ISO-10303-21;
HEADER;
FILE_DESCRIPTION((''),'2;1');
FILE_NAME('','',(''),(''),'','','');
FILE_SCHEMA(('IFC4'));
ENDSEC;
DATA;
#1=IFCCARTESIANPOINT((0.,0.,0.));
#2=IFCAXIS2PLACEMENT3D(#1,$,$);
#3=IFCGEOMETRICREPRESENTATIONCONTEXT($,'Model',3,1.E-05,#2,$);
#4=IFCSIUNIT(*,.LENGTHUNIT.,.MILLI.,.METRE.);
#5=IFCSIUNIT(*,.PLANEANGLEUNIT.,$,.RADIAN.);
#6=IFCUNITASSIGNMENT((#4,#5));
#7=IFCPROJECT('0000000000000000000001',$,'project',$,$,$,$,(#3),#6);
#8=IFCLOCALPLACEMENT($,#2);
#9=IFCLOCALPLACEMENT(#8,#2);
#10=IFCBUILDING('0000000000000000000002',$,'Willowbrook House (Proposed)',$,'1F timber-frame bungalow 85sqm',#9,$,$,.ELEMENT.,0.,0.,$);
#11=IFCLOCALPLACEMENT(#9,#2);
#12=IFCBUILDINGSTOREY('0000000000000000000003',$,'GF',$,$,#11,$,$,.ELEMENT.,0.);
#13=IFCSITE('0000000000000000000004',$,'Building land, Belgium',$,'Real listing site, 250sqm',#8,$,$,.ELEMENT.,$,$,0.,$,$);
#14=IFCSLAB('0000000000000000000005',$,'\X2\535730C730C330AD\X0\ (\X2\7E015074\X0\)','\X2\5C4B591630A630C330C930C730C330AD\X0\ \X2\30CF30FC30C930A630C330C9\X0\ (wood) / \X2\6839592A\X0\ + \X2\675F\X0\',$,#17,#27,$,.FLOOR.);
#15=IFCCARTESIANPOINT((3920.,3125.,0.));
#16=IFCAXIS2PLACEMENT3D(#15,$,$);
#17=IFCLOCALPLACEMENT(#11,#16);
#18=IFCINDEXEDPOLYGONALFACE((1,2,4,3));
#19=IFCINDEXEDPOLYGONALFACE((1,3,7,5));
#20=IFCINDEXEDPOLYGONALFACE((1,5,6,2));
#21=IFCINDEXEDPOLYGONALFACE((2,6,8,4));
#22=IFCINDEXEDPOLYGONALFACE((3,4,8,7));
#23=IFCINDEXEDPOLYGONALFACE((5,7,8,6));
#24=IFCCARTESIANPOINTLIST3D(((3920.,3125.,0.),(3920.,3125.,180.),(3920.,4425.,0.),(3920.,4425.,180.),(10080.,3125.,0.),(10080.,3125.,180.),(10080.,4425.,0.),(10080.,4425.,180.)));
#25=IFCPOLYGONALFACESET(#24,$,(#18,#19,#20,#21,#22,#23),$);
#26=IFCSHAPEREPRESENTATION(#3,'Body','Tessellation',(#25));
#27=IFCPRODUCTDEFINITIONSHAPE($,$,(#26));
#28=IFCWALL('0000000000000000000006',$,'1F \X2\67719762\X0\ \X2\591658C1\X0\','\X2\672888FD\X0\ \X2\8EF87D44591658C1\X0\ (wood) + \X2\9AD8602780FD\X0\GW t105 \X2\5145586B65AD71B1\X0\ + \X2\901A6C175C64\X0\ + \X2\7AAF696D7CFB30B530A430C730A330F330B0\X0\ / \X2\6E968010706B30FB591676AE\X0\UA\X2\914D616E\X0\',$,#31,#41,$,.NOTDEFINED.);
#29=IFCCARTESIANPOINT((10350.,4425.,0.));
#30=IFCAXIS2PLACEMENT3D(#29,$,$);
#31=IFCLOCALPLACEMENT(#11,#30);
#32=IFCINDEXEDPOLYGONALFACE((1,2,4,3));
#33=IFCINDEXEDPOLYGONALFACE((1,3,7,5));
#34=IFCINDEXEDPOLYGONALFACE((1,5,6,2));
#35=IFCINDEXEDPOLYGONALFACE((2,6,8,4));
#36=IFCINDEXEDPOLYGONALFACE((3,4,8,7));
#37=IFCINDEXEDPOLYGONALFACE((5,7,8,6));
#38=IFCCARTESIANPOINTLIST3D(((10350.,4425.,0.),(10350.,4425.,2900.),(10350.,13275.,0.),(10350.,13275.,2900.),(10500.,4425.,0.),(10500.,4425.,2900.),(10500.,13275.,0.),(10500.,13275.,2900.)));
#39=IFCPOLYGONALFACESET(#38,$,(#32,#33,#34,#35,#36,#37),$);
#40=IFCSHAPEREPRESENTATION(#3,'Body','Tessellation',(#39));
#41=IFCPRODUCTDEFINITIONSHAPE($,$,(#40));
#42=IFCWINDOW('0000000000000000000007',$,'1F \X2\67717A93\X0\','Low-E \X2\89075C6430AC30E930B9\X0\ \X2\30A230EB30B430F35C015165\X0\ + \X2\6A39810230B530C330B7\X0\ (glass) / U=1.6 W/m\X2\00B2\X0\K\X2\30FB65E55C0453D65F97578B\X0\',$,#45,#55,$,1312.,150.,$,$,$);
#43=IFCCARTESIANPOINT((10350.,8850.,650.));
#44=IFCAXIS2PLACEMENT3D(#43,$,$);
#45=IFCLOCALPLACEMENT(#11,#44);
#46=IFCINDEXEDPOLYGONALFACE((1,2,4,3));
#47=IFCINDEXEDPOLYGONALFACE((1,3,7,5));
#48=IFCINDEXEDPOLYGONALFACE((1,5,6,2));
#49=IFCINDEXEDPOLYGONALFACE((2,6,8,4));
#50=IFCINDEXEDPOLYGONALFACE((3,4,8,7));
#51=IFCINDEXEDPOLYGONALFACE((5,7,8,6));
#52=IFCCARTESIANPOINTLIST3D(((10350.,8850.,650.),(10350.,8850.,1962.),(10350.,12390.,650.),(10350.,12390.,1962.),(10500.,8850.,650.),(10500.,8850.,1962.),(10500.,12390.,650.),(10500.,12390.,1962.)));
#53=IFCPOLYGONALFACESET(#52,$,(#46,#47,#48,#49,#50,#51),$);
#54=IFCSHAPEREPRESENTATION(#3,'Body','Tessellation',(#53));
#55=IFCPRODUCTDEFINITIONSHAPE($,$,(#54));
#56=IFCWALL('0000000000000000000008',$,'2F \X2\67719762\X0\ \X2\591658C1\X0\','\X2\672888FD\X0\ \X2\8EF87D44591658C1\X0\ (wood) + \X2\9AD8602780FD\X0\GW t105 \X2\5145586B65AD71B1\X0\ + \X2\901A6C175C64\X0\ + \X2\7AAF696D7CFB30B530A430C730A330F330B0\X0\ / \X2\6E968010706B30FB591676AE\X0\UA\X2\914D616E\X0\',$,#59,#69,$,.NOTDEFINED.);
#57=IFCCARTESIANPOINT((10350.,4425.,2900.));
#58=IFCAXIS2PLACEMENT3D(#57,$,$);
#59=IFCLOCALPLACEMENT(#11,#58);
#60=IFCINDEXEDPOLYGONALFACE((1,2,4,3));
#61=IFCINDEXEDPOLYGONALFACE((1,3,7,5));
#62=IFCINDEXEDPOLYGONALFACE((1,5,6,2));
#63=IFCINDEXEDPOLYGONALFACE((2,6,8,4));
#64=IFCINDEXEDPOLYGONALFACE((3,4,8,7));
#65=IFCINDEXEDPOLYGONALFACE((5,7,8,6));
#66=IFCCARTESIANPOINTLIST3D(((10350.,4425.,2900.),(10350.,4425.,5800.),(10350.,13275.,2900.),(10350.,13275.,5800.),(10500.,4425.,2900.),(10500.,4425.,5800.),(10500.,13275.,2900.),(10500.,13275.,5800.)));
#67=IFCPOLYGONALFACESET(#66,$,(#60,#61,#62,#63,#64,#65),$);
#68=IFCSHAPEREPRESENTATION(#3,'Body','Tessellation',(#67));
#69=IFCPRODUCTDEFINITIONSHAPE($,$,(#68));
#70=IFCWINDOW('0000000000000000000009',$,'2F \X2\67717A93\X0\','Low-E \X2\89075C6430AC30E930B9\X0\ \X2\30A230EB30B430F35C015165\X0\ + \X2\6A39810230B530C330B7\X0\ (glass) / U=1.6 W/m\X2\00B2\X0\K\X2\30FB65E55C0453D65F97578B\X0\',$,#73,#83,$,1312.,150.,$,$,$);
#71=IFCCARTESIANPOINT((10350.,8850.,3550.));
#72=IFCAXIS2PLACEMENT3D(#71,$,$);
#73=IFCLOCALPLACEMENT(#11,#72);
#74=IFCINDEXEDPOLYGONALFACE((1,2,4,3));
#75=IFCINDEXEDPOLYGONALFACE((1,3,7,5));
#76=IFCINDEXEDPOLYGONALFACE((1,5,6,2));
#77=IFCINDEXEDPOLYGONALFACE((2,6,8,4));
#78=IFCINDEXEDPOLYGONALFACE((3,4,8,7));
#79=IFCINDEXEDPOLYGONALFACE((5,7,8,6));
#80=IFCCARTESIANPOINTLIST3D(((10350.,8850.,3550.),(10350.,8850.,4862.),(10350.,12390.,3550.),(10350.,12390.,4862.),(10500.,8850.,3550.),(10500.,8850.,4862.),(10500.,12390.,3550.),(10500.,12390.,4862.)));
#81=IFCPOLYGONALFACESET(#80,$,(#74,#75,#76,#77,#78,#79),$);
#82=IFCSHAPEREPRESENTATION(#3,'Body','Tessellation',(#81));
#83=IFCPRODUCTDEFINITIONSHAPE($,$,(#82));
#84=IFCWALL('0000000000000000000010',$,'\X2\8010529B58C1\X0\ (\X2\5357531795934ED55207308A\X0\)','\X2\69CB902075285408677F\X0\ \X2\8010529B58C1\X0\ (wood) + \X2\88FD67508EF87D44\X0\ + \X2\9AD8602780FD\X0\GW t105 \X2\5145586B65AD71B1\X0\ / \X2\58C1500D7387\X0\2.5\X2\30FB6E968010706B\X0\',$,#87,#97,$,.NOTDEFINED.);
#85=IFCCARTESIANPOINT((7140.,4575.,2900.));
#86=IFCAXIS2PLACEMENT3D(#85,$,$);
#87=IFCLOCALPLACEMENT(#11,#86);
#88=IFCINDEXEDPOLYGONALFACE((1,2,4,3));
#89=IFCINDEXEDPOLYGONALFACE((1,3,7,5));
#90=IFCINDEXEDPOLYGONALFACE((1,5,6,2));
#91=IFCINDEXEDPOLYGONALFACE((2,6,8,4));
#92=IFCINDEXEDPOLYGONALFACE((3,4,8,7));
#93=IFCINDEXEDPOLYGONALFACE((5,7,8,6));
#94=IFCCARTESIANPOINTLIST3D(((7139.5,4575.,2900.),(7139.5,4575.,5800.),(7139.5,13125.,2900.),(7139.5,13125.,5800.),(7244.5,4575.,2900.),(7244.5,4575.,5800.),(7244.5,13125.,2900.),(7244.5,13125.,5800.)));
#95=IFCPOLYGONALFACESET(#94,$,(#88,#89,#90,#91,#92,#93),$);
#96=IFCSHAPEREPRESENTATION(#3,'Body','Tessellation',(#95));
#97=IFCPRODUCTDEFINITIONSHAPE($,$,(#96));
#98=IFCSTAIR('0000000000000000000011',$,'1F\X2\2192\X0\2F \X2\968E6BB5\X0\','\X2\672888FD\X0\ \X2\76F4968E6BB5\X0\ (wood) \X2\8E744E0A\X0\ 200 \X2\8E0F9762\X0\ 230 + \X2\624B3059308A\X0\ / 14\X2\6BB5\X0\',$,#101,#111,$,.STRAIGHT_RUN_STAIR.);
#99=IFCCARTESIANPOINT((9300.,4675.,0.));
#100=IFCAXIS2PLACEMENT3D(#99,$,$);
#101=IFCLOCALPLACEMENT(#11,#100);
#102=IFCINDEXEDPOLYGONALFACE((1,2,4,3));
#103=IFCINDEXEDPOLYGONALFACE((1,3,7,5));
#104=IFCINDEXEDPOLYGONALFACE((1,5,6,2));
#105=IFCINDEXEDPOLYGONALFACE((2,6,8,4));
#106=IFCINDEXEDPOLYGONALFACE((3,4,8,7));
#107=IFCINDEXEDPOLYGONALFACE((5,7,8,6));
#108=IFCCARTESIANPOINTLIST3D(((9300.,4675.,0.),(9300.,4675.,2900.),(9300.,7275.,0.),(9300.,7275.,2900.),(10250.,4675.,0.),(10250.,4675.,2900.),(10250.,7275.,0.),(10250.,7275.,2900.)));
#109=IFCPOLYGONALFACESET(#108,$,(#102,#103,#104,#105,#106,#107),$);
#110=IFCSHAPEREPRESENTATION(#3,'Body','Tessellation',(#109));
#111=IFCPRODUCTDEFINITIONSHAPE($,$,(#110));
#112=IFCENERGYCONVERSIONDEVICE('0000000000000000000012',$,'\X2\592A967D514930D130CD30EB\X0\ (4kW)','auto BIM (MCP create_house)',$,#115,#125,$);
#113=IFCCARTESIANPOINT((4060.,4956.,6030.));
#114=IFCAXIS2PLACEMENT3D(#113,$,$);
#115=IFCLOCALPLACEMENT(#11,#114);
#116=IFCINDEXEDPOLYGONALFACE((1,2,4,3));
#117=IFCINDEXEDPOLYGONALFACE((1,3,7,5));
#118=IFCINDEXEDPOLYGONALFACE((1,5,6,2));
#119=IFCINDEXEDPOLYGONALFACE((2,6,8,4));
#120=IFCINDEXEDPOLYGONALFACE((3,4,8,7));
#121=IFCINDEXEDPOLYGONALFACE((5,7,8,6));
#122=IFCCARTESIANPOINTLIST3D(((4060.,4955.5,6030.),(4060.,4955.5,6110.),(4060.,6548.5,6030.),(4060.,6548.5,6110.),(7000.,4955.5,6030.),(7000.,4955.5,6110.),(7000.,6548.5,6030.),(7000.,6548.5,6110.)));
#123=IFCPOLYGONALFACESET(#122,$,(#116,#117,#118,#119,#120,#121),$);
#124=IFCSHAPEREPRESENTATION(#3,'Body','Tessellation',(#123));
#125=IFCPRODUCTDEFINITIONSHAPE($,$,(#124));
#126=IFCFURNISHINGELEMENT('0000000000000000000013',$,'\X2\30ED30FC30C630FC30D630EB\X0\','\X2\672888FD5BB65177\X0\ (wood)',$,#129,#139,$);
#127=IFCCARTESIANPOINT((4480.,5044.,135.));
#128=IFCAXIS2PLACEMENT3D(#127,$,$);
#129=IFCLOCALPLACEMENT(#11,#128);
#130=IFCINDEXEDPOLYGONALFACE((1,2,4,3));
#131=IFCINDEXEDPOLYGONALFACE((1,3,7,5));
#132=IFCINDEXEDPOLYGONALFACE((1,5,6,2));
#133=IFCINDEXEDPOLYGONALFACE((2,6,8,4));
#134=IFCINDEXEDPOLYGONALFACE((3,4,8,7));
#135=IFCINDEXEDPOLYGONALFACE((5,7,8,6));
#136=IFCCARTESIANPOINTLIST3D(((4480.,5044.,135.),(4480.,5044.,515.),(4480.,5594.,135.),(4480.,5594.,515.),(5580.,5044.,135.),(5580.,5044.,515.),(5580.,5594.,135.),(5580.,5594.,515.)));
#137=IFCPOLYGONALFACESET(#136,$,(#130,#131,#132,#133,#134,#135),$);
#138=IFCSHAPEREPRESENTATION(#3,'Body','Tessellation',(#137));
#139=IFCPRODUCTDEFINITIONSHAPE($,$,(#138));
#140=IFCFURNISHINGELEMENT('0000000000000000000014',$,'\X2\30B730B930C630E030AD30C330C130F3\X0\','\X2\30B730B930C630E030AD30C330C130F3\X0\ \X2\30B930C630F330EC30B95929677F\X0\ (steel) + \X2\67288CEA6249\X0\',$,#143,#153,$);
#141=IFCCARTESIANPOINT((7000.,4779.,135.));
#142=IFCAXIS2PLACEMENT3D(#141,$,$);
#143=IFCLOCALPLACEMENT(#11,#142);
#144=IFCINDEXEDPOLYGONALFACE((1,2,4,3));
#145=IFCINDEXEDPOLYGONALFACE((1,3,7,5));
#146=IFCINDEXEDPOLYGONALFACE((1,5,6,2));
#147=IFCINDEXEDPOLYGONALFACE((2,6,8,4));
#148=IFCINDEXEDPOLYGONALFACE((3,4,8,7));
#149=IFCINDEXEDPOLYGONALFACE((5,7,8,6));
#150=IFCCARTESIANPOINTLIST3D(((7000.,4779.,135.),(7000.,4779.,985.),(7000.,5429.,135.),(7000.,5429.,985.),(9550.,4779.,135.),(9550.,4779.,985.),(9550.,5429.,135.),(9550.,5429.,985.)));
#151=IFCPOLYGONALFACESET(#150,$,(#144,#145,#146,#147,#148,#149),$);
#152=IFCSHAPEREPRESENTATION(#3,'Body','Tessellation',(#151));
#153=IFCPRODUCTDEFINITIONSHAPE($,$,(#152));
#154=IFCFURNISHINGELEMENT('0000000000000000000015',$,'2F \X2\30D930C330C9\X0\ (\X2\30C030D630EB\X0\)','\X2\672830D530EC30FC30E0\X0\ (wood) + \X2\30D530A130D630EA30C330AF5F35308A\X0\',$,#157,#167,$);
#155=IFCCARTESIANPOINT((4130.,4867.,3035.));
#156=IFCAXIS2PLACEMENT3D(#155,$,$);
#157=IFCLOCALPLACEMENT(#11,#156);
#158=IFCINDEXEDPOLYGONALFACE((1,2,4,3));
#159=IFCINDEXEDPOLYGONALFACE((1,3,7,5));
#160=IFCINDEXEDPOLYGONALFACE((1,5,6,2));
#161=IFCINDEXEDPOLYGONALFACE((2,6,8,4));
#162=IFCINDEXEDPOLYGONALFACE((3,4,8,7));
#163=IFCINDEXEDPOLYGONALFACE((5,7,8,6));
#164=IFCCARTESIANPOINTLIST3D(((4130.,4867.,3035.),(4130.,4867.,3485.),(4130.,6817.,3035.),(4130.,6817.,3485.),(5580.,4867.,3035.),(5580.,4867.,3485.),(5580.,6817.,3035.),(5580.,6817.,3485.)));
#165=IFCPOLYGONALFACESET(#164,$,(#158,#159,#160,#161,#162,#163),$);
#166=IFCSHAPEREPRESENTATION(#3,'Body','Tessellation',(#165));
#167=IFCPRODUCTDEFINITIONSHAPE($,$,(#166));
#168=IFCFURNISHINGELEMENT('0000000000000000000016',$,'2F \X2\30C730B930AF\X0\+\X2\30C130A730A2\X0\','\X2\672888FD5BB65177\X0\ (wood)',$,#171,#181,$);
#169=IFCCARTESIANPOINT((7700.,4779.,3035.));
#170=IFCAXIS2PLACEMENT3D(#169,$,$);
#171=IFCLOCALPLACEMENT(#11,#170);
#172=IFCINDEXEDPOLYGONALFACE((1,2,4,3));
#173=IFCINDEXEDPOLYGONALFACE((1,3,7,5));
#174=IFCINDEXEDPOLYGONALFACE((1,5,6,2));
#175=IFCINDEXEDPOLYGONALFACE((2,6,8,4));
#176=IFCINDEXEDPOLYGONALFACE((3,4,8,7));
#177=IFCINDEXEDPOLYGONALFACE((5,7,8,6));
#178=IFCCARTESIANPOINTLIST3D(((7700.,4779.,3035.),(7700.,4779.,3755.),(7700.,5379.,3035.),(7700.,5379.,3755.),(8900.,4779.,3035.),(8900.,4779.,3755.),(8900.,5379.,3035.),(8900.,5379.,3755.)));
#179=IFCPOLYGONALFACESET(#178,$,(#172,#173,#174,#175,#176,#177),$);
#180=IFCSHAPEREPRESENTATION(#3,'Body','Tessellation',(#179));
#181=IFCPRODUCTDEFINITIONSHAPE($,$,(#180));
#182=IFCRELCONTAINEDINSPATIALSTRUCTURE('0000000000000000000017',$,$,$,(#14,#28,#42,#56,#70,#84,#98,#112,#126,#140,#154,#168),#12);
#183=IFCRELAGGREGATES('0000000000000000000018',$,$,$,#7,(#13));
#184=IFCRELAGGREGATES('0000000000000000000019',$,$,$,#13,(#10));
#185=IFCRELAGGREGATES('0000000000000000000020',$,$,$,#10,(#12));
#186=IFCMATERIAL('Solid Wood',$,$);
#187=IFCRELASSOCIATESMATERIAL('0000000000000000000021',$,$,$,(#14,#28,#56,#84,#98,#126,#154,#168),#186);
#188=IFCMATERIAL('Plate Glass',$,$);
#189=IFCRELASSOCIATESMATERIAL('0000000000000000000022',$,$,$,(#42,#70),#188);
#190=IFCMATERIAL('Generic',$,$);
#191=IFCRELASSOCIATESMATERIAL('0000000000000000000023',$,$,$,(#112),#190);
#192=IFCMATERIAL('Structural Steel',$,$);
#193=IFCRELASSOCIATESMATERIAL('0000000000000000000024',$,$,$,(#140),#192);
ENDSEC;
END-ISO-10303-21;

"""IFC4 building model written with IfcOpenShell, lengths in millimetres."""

from ifc_helpers import new_model, si_unit, frame, frame_2d, origin, place, context, project, spatial, rectangle, extrude, material, element, fill, save


model = new_model("IFC4")

# Units and contexts
model_context = context("Model", 3, precision=1e-05, world=origin())
ifc_project = project(units=[si_unit("LENGTHUNIT", "METRE", prefix="MILLI"), si_unit("PLANEANGLEUNIT", "RADIAN")], contexts=[model_context])

# Site, building, storey
site_placement = place(None, origin())
site = spatial("IfcSite", under=ifc_project, at=site_placement, Name="Building land, Belgium", ObjectType="Real listing site, 250sqm", CompositionType="ELEMENT", RefElevation=0.0)
building_placement = place(site_placement, origin())
building = spatial("IfcBuilding", under=site, at=building_placement, Name="Willowbrook House (Proposed)", ObjectType="1F timber-frame bungalow 85sqm", CompositionType="ELEMENT", ElevationOfRefHeight=0.0, ElevationOfTerrain=0.0)
storey_placement = place(building_placement, origin())
storey = spatial("IfcBuildingStorey", under=building, at=storey_placement, Name="GF", CompositionType="ELEMENT", Elevation=0.0)

# Slab
ifc_material_1 = material(Name="Solid Wood")
slab_placement = place(storey_placement, frame((3920.0, 3125.0, 0.0)))
element("IfcSlab", 1, at=slab_placement, inside=storey, material=ifc_material_1, Name="南デッキ (縁側)", Description="屋外ウッドデッキ ハードウッド (wood) / 根太 + 束", PredefinedType="FLOOR", context=model_context, shape_type="SweptSolid", body=[
    extrude(rectangle(XDim=6160.0, YDim=1300.0, at=frame_2d((3080.0, 650.0))), frame((3920.0, 3125.0, 0.0)), (0.0, 0.0, 1.0), 180.0),
])

# Wall, opening, window
wall_1_placement = place(storey_placement, frame((10350.0, 4425.0, 0.0)))
wall_1 = element("IfcWall", 2, at=wall_1_placement, inside=storey, material=ifc_material_1, Name="1F 東面 外壁", Description="木製 軸組外壁 (wood) + 高性能GW t105 充填断熱 + 通気層 + 窯業系サイディング / 準耐火・外皮UA配慮", PredefinedType="NOTDEFINED", context=model_context, shape_type="SweptSolid", body=[
    extrude(rectangle(XDim=150.0, YDim=8850.0, at=frame_2d((75.0, 4425.0))), frame((10350.0, 4425.0, 0.0)), (0.0, 0.0, 1.0), 2900.0),
])
opening_1_placement = place(storey_placement, frame((10350.0, 8850.0, 650.0)))
opening_1 = element("IfcOpeningElement", 3, at=opening_1_placement, cuts=wall_1, PredefinedType="NOTDEFINED", context=model_context, shape_type="SweptSolid", body=[
    extrude(rectangle(XDim=150.0, YDim=3540.0, at=frame_2d((75.0, 1770.0))), frame((10350.0, 8850.0, 650.0)), (0.0, 0.0, 1.0), 1312.0),
])
ifc_material_2 = material(Name="Plate Glass")
window_1_placement = place(storey_placement, frame((10350.0, 8850.0, 650.0)))
window_1 = element("IfcWindow", 4, at=window_1_placement, inside=storey, material=ifc_material_2, Name="1F 東窓", Description="Low-E 複層ガラス アルゴン封入 + 樹脂サッシ (glass) / U=1.6 W/m²K・日射取得型", OverallHeight=1312.0, OverallWidth=150.0, context=model_context, shape_type="SweptSolid", body=[
    extrude(rectangle(XDim=150.0, YDim=3540.0, at=frame_2d((75.0, 1770.0))), frame((10350.0, 8850.0, 650.0)), (0.0, 0.0, 1.0), 1312.0),
])
fill(opening_1, window_1)

# Wall, opening, window
wall_2_placement = place(storey_placement, frame((10350.0, 4425.0, 2900.0)))
wall_2 = element("IfcWall", 5, at=wall_2_placement, inside=storey, material=ifc_material_1, Name="2F 東面 外壁", Description="木製 軸組外壁 (wood) + 高性能GW t105 充填断熱 + 通気層 + 窯業系サイディング / 準耐火・外皮UA配慮", PredefinedType="NOTDEFINED", context=model_context, shape_type="SweptSolid", body=[
    extrude(rectangle(XDim=150.0, YDim=8850.0, at=frame_2d((75.0, 4425.0))), frame((10350.0, 4425.0, 2900.0)), (0.0, 0.0, 1.0), 2900.0),
])
opening_2_placement = place(storey_placement, frame((10350.0, 8850.0, 3550.0)))
opening_2 = element("IfcOpeningElement", 6, at=opening_2_placement, cuts=wall_2, PredefinedType="NOTDEFINED", context=model_context, shape_type="SweptSolid", body=[
    extrude(rectangle(XDim=150.0, YDim=3540.0, at=frame_2d((75.0, 1770.0))), frame((10350.0, 8850.0, 3550.0)), (0.0, 0.0, 1.0), 1312.0),
])
window_2_placement = place(storey_placement, frame((10350.0, 8850.0, 3550.0)))
window_2 = element("IfcWindow", 7, at=window_2_placement, inside=storey, material=ifc_material_2, Name="2F 東窓", Description="Low-E 複層ガラス アルゴン封入 + 樹脂サッシ (glass) / U=1.6 W/m²K・日射取得型", OverallHeight=1312.0, OverallWidth=150.0, context=model_context, shape_type="SweptSolid", body=[
    extrude(rectangle(XDim=150.0, YDim=3540.0, at=frame_2d((75.0, 1770.0))), frame((10350.0, 8850.0, 3550.0)), (0.0, 0.0, 1.0), 1312.0),
])
fill(opening_2, window_2)

# Wall
wall_3_placement = place(storey_placement, frame((7140.0, 4575.0, 2900.0)))
element("IfcWall", 8, at=wall_3_placement, inside=storey, material=ifc_material_1, Name="耐力壁 (南北間仕切り)", Description="構造用合板 耐力壁 (wood) + 製材軸組 + 高性能GW t105 充填断熱 / 壁倍率2.5・準耐火", PredefinedType="NOTDEFINED", context=model_context, shape_type="SweptSolid", body=[
    extrude(rectangle(XDim=105.0, YDim=8550.0, at=frame_2d((52.0, 4275.0))), frame((7140.0, 4575.0, 2900.0)), (0.0, 0.0, 1.0), 2900.0),
])

# Stair
stair_placement = place(storey_placement, frame((9300.0, 4675.0, 0.0)))
element("IfcStair", 9, at=stair_placement, inside=storey, material=ifc_material_1, Name="1F→2F 階段", Description="木製 直階段 (wood) 蹴上 200 踏面 230 + 手すり / 14段", PredefinedType="STRAIGHT_RUN_STAIR", context=model_context, shape_type="SweptSolid", body=[
    extrude(rectangle(XDim=950.0, YDim=2600.0, at=frame_2d((475.0, 1300.0))), frame((9300.0, 4675.0, 0.0)), (0.0, 0.0, 1.0), 2900.0),
])

# Energy conversion device
ifc_material_3 = material(Name="Generic")
energy_conversion_device_placement = place(storey_placement, frame((4060.0, 4956.0, 6030.0)))
element("IfcEnergyConversionDevice", 10, at=energy_conversion_device_placement, inside=storey, material=ifc_material_3, Name="太陽光パネル (4kW)", Description="auto BIM (MCP create_house)", context=model_context, shape_type="SweptSolid", body=[
    extrude(rectangle(XDim=2940.0, YDim=1593.0, at=frame_2d((1470.0, 796.0))), frame((4060.0, 4956.0, 6030.0)), (0.0, 0.0, 1.0), 80.0),
])

# Furnishing elements
furnishing_1_placement = place(storey_placement, frame((4480.0, 5044.0, 135.0)))
element("IfcFurnishingElement", 11, at=furnishing_1_placement, inside=storey, material=ifc_material_1, Name="ローテーブル", Description="木製家具 (wood)", context=model_context, shape_type="SweptSolid", body=[
    extrude(rectangle(XDim=1100.0, YDim=550.0, at=frame_2d((550.0, 275.0))), frame((4480.0, 5044.0, 135.0)), (0.0, 0.0, 1.0), 380.0),
])
ifc_material_4 = material(Name="Structural Steel")
furnishing_2_placement = place(storey_placement, frame((7000.0, 4779.0, 135.0)))
element("IfcFurnishingElement", 12, at=furnishing_2_placement, inside=storey, material=ifc_material_4, Name="システムキッチン", Description="システムキッチン ステンレス天板 (steel) + 木質扉", context=model_context, shape_type="SweptSolid", body=[
    extrude(rectangle(XDim=2550.0, YDim=650.0, at=frame_2d((1275.0, 325.0))), frame((7000.0, 4779.0, 135.0)), (0.0, 0.0, 1.0), 850.0),
])
furnishing_3_placement = place(storey_placement, frame((4130.0, 4867.0, 3035.0)))
element("IfcFurnishingElement", 13, at=furnishing_3_placement, inside=storey, material=ifc_material_1, Name="2F ベッド (ダブル)", Description="木フレーム (wood) + ファブリック張り", context=model_context, shape_type="SweptSolid", body=[
    extrude(rectangle(XDim=1450.0, YDim=1950.0, at=frame_2d((725.0, 975.0))), frame((4130.0, 4867.0, 3035.0)), (0.0, 0.0, 1.0), 450.0),
])
furnishing_4_placement = place(storey_placement, frame((7700.0, 4779.0, 3035.0)))
element("IfcFurnishingElement", 14, at=furnishing_4_placement, inside=storey, material=ifc_material_1, Name="2F デスク+チェア", Description="木製家具 (wood)", context=model_context, shape_type="SweptSolid", body=[
    extrude(rectangle(XDim=1200.0, YDim=600.0, at=frame_2d((600.0, 300.0))), frame((7700.0, 4779.0, 3035.0)), (0.0, 0.0, 1.0), 720.0),
])

save(model, "model.ifc")
